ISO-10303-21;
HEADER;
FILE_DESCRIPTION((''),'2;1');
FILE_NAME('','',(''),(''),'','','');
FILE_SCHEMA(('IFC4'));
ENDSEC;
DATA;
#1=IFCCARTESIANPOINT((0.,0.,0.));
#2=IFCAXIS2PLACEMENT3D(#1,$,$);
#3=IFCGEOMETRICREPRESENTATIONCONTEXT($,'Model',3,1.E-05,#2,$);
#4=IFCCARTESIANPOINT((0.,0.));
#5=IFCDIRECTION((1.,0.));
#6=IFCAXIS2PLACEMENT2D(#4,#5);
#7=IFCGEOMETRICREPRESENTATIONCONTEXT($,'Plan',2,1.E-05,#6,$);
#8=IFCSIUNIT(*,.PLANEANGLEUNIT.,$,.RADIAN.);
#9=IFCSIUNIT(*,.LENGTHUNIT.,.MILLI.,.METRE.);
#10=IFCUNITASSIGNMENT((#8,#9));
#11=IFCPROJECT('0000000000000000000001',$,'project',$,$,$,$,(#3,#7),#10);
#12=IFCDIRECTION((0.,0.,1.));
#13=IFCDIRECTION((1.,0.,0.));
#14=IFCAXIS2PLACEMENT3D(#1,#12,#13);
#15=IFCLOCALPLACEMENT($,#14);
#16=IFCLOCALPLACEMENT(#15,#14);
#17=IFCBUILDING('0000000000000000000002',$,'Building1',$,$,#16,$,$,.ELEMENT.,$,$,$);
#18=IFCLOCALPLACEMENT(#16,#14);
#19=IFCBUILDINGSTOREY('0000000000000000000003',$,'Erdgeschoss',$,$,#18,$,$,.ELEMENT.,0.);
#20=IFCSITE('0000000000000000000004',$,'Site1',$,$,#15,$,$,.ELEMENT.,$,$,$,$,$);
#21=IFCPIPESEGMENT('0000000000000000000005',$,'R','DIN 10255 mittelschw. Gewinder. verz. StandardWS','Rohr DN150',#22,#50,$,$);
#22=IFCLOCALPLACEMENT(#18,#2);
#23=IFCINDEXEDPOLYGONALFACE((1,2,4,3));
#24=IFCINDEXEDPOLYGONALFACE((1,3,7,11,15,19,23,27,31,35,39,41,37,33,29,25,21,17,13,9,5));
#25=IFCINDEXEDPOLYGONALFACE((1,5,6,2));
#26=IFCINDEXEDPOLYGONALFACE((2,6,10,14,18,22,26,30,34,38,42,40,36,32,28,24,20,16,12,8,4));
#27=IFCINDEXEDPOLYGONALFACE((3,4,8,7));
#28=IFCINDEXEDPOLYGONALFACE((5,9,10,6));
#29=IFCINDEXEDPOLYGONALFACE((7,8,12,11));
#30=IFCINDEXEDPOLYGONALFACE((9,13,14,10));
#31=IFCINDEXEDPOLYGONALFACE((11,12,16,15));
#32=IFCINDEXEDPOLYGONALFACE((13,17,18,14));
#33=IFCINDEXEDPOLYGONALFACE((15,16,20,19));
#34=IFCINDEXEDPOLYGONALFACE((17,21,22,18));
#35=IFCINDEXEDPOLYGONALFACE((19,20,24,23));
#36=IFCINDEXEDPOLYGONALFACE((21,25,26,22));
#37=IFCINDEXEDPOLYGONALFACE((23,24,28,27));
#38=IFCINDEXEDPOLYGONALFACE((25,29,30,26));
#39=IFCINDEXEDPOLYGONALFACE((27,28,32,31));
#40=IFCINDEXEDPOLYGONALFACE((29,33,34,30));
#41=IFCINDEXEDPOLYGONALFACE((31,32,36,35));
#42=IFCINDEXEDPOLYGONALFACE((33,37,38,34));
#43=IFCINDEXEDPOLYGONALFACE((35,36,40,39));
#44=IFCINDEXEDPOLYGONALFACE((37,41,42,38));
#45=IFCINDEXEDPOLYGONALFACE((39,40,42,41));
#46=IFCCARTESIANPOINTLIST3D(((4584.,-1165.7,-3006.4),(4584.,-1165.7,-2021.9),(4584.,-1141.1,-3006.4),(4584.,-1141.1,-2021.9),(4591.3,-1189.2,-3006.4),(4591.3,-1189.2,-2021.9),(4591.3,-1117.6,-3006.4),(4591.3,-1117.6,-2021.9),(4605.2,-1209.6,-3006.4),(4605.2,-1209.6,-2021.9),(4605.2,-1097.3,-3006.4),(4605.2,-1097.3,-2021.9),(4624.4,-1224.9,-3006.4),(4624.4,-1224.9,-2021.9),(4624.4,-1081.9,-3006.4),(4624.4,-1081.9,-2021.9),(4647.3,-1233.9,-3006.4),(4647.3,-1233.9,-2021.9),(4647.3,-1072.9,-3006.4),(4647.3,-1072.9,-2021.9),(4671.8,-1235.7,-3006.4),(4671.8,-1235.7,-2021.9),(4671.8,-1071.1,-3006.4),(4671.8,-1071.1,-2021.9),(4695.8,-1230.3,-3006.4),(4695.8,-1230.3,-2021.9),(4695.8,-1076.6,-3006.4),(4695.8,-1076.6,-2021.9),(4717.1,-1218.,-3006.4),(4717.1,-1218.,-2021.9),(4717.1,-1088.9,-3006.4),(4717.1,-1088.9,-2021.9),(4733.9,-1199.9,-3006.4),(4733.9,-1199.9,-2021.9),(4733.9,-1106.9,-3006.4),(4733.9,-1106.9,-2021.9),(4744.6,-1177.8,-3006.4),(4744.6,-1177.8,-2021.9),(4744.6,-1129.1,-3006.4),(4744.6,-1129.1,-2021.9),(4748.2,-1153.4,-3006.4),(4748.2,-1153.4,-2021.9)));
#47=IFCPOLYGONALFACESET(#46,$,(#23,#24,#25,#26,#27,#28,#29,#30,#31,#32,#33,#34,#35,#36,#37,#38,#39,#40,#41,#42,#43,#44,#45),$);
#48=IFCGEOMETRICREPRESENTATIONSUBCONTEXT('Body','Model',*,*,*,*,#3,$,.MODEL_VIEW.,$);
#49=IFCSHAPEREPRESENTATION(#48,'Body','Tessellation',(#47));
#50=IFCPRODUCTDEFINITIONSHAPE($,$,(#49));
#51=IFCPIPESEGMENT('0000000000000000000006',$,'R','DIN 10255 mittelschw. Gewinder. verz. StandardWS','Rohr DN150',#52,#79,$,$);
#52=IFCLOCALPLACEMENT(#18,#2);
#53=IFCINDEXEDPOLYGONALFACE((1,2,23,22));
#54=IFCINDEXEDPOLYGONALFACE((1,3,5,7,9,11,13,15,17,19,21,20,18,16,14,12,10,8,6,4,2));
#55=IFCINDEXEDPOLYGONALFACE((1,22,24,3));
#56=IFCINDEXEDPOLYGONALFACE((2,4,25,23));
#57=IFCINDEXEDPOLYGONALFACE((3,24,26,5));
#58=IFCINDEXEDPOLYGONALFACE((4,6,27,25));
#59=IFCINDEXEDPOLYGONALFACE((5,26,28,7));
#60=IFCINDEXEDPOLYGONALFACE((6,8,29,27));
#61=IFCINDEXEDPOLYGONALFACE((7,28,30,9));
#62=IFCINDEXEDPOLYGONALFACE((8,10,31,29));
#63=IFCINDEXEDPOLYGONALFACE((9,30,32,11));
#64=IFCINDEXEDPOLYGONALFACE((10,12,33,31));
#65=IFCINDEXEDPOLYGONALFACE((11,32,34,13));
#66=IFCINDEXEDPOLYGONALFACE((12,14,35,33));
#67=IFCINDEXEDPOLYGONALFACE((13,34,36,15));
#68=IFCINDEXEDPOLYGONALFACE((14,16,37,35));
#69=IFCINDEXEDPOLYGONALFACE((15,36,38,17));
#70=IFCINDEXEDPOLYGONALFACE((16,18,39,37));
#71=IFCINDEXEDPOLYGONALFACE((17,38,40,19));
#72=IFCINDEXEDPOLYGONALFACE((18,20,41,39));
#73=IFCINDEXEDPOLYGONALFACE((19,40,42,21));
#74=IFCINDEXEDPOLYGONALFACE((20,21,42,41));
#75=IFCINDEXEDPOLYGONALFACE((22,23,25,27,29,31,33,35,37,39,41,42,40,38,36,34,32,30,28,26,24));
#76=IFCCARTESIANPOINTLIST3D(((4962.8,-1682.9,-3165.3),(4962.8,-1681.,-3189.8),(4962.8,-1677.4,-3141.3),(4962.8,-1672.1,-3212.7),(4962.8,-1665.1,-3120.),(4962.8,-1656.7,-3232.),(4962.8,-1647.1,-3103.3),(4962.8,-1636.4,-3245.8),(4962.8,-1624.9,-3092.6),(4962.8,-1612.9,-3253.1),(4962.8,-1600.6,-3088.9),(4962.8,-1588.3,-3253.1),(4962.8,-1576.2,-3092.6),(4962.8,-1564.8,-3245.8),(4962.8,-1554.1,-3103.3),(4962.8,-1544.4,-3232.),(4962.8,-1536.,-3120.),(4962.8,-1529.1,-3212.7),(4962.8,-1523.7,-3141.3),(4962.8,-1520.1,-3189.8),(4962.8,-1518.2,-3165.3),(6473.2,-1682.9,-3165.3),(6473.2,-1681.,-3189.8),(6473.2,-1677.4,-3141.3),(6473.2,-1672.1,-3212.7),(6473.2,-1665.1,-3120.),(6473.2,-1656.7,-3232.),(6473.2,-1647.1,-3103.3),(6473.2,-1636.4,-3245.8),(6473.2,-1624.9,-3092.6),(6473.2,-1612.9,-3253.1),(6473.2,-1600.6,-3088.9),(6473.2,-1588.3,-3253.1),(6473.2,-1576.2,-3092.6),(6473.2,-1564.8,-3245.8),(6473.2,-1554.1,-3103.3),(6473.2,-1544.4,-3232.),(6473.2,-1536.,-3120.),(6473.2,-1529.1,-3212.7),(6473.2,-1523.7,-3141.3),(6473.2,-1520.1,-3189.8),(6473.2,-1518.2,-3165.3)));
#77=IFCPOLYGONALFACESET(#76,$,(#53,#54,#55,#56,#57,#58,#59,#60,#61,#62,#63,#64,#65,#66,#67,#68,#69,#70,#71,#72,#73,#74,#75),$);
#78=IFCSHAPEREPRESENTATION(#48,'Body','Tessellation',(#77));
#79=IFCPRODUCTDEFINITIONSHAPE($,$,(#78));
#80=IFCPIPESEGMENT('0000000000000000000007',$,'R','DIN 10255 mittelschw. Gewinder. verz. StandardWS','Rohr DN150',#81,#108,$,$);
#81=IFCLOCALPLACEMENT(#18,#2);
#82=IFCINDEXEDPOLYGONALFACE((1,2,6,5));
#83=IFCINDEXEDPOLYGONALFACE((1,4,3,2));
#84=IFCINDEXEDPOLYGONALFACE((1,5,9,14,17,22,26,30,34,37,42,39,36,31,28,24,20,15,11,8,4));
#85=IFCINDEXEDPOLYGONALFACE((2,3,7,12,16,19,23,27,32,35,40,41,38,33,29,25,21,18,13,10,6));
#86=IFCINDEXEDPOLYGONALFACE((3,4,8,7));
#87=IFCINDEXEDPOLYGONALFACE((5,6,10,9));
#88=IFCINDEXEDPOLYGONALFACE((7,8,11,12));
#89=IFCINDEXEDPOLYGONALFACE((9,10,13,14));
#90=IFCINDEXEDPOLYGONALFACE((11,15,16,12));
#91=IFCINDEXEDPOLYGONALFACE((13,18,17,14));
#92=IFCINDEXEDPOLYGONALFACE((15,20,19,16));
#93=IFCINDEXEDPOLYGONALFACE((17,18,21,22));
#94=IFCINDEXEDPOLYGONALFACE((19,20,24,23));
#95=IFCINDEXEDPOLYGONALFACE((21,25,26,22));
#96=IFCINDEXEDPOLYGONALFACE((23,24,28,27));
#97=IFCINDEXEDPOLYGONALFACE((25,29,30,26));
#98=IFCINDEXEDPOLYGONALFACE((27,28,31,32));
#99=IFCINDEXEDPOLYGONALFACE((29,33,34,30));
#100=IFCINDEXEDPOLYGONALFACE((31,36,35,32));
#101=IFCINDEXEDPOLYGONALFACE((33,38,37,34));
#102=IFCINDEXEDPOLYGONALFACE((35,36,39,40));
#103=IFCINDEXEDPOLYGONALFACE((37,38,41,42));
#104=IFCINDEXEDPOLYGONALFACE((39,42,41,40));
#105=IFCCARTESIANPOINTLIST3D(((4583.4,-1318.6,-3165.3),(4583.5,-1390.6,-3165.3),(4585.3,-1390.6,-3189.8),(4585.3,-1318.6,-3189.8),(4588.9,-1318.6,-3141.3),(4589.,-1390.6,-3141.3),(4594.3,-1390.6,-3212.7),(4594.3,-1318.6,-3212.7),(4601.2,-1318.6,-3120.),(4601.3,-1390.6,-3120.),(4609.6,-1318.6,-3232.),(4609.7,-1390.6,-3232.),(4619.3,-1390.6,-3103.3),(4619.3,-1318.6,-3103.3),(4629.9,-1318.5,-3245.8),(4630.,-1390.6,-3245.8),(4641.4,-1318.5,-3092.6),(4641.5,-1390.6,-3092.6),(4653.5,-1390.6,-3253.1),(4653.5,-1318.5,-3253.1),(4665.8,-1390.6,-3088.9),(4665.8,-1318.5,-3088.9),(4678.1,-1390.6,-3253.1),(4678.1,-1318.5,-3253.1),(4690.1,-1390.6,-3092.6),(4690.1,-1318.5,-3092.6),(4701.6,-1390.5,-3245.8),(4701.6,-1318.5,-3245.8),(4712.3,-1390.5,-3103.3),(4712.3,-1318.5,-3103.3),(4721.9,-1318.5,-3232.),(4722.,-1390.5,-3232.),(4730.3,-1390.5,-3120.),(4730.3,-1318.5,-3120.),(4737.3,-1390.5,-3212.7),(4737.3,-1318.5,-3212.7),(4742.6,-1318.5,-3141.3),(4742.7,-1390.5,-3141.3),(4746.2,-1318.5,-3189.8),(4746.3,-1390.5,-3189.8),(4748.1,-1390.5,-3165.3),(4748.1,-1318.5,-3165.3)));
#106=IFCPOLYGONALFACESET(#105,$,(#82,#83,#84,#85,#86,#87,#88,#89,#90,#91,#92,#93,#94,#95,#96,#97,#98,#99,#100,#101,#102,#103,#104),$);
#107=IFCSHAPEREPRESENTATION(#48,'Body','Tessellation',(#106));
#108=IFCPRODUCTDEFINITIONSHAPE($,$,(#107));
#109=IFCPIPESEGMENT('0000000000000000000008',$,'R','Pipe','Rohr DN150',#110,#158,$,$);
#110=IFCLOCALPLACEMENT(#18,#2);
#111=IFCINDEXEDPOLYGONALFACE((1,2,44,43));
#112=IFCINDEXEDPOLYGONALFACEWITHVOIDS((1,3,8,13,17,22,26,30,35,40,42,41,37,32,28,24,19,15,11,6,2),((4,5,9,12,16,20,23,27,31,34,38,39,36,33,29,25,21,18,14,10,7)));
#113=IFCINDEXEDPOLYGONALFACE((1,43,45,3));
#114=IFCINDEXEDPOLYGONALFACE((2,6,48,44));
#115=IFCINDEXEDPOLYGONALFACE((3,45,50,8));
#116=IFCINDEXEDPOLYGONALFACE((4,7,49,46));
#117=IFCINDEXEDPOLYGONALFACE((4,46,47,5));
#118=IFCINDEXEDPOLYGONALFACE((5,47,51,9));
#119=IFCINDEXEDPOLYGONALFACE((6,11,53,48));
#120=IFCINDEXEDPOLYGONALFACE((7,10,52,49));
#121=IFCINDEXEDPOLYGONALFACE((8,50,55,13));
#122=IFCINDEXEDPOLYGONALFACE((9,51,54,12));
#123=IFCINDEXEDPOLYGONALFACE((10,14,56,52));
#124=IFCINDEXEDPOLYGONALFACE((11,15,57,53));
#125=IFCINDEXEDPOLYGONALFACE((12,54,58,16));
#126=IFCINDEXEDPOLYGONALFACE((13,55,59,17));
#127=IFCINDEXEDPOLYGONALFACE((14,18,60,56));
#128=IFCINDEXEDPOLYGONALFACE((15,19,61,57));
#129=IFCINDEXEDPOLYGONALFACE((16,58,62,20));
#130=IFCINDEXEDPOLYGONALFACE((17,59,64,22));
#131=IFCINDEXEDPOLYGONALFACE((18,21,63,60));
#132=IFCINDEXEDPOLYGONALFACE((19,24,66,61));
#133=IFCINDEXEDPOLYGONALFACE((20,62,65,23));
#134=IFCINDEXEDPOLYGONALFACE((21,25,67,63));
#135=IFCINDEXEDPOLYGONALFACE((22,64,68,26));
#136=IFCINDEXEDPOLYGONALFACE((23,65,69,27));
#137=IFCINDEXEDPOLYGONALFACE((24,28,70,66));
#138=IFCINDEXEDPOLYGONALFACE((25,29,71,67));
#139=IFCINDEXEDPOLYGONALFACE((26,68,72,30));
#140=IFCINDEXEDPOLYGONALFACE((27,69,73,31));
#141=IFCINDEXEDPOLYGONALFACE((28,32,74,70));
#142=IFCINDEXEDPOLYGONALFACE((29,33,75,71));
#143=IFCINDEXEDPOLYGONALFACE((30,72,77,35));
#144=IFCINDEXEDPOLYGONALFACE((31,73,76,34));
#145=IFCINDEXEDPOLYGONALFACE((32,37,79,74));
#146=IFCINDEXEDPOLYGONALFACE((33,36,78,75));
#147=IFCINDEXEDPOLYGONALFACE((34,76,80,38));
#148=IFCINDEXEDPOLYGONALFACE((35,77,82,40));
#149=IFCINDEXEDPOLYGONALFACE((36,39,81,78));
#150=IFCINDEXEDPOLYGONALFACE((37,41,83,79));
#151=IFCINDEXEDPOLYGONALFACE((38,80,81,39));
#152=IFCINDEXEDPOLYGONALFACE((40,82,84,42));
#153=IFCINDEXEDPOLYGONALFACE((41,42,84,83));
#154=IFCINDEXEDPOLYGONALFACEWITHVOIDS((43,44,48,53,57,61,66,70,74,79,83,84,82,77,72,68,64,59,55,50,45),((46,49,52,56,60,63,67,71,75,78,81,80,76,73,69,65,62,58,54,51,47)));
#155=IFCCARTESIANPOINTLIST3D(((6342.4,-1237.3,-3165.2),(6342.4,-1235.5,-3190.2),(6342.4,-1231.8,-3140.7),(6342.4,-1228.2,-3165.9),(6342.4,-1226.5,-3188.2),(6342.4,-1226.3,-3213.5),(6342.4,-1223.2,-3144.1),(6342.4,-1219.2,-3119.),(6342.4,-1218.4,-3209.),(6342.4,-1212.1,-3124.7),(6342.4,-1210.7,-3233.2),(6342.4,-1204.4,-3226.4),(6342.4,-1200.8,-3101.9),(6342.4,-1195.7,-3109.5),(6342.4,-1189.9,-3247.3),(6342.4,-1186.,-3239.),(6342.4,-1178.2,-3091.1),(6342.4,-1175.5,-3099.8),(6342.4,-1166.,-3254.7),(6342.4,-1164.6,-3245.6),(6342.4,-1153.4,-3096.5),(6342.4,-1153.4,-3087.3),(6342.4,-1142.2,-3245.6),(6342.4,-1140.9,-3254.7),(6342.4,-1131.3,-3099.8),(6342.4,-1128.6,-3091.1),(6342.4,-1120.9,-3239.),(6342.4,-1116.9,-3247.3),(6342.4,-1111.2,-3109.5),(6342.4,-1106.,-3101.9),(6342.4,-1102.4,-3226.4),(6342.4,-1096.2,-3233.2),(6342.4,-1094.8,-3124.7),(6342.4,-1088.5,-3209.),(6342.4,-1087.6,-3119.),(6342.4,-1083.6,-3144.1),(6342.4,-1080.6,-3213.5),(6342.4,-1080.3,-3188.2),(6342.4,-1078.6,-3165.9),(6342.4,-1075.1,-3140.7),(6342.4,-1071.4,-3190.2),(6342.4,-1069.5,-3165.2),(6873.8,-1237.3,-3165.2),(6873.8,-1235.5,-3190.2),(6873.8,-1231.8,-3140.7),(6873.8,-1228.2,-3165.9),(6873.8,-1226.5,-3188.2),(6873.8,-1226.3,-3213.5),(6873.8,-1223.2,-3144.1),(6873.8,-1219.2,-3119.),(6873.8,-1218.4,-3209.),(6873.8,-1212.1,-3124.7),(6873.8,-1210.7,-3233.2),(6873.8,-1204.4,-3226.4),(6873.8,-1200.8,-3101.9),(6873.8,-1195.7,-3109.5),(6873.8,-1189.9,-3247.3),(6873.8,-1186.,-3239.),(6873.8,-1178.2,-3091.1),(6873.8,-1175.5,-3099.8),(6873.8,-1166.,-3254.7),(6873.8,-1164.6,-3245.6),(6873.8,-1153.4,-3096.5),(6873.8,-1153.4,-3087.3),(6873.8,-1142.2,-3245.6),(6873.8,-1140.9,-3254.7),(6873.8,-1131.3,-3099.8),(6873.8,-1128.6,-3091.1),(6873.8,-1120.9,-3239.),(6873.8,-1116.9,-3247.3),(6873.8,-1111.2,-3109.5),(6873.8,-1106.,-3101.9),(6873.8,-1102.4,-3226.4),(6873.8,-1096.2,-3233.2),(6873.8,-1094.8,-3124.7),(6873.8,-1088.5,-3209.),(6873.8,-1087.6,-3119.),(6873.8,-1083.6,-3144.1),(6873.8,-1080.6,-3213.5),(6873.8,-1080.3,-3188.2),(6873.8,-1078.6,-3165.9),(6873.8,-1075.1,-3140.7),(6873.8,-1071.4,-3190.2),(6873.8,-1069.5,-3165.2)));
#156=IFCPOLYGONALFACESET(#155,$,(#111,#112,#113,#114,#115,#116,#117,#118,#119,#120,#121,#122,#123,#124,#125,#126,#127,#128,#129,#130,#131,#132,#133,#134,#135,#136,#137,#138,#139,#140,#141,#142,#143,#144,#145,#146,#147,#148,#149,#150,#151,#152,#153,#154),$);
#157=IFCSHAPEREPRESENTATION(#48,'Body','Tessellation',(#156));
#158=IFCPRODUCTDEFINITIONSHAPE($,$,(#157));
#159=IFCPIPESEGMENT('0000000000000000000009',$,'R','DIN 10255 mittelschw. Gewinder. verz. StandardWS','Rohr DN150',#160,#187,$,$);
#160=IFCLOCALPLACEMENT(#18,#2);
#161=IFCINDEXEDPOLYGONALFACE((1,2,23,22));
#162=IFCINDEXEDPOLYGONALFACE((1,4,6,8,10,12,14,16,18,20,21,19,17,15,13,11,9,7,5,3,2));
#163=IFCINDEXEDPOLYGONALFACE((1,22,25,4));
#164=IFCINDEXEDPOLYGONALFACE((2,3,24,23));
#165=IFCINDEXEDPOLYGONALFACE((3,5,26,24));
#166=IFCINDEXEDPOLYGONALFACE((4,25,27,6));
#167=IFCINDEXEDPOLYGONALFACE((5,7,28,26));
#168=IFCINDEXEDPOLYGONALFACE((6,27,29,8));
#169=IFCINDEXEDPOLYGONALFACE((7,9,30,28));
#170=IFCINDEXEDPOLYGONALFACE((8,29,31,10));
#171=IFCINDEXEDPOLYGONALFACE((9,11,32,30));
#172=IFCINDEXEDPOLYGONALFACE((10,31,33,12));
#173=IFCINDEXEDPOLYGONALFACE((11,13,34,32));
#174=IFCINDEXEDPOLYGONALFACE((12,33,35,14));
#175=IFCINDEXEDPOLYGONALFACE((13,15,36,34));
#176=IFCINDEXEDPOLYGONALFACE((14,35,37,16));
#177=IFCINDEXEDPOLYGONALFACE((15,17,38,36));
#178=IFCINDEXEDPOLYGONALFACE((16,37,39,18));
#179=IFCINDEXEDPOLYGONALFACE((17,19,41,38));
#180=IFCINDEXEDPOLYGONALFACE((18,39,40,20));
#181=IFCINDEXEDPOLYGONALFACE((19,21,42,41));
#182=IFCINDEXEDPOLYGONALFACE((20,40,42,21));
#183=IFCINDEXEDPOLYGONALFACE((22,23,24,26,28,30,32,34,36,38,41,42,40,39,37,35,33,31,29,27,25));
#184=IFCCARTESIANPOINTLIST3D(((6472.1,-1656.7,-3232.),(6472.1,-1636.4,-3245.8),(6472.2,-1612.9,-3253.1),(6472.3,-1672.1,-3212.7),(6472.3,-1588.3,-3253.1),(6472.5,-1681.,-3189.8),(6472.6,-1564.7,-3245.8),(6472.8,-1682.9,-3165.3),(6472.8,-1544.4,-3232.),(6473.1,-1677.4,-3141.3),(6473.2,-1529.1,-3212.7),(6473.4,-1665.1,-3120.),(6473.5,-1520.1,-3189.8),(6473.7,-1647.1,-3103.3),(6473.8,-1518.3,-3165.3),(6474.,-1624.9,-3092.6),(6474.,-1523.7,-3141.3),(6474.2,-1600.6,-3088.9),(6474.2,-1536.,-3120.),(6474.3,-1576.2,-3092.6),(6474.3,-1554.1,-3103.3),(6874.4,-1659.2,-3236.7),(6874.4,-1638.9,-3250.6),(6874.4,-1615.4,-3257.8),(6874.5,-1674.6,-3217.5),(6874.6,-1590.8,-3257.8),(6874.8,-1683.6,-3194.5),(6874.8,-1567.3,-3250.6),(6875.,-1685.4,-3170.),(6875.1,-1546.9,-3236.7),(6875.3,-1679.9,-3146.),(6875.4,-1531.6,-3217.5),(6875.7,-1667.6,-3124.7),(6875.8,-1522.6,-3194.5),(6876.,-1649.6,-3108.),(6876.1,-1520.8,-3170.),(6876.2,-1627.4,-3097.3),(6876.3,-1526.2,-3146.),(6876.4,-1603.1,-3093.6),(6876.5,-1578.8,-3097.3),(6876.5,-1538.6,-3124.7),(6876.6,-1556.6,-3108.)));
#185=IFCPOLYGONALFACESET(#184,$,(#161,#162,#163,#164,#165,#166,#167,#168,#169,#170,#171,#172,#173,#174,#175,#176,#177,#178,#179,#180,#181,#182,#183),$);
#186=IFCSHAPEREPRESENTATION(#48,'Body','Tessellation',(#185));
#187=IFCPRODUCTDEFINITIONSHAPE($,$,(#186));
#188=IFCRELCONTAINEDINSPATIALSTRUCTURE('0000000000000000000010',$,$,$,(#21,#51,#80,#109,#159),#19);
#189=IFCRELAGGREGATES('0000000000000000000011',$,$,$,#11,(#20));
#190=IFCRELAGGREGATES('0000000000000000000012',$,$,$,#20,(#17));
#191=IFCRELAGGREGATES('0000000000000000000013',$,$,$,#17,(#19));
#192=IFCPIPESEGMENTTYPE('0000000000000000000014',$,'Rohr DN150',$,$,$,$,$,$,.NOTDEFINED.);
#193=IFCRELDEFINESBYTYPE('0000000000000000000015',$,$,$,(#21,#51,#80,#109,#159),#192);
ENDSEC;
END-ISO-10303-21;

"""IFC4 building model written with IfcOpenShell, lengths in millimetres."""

from ifc_helpers import new_model, si_unit, frame, origin, origin_with_axes, origin_2d_with_axis, place, context, subcontext, project, spatial, circle, hollow_circle, extrude, type_object, element, save


model = new_model("IFC4")

# Units and contexts
model_context = context("Model", 3, precision=1e-05, world=origin())
plan_context = context("Plan", 2, precision=1e-05, world=origin_2d_with_axis())
body_context = subcontext(model_context, "Body", "Model", "MODEL_VIEW")
ifc_project = project(units=[si_unit("PLANEANGLEUNIT", "RADIAN"), si_unit("LENGTHUNIT", "METRE", prefix="MILLI")], contexts=[model_context, plan_context])

# Site, building, storey
site_placement = place(None, origin_with_axes())
site = spatial("IfcSite", under=ifc_project, at=site_placement, Name="Site1", CompositionType="ELEMENT")
building_placement = place(site_placement, origin_with_axes())
building = spatial("IfcBuilding", under=site, at=building_placement, Name="Building1", CompositionType="ELEMENT")
storey_placement = place(building_placement, origin_with_axes())
storey = spatial("IfcBuildingStorey", under=building, at=storey_placement, Name="Erdgeschoss", CompositionType="ELEMENT", Elevation=0.0)

# Pipe segments
pipe_segment_type_1 = type_object("IfcPipeSegmentType", Name="Rohr DN150", PredefinedType="NOTDEFINED")
pipe_segment_1_placement = place(storey_placement, frame((4665.7, -1153.6, -2514.1), z_axis=(0.0, 0.0, 1.0), x_axis=(1.0, 0.0, 0.0)))
element("IfcPipeSegment", 1, at=pipe_segment_1_placement, inside=storey, type_object=pipe_segment_type_1, Name="R", Description="DIN 10255 mittelschw. Gewinder. verz. StandardWS", ObjectType="Rohr DN150", context=body_context, shape_type="SolidModel", body=[
    extrude(circle(Radius=82.5, at=origin_2d_with_axis()), frame((0.0, 0.2, -492.3), z_axis=(0.0, 0.0, 1.0), x_axis=(1.0, 0.0, 0.0)), (0.0, 0.0, 1.0), 984.5),
])
pipe_segment_2_placement = place(storey_placement, frame((5718.0, -1600.7, -3171.5), z_axis=(0.0, 0.0, 1.0), x_axis=(1.0, 0.0, 0.0)))
element("IfcPipeSegment", 2, at=pipe_segment_2_placement, inside=storey, type_object=pipe_segment_type_1, Name="R", Description="DIN 10255 mittelschw. Gewinder. verz. StandardWS", ObjectType="Rohr DN150", context=body_context, shape_type="SolidModel", body=[
    extrude(circle(Radius=82.5, at=origin_2d_with_axis()), frame((755.2, 0.1, 0.0), z_axis=(-1.0, 0.0, 0.0), x_axis=(0.0, 0.0, 1.0)), (0.0, 0.0, 1.0), 1510.4),
])
pipe_segment_3_placement = place(storey_placement, frame((4665.6, -1354.5, -3171.5), z_axis=(0.0, 0.0, 1.0), x_axis=(1.0, 0.0, 0.0)))
element("IfcPipeSegment", 3, at=pipe_segment_3_placement, inside=storey, type_object=pipe_segment_type_1, Name="R", Description="DIN 10255 mittelschw. Gewinder. verz. StandardWS", ObjectType="Rohr DN150", context=body_context, shape_type="SolidModel", body=[
    extrude(circle(Radius=82.5, at=origin_2d_with_axis()), frame((0.2, -36.0, 0.0), z_axis=(-0.000562, 1.0, 0.0), x_axis=(0.0, 0.0, 1.0)), (0.0, 0.0, 1.0), 72.0),
])
pipe_segment_4_placement = place(storey_placement, frame((6608.1, -1153.6, -3171.5), z_axis=(0.0, 0.0, 1.0), x_axis=(1.0, 0.0, 0.0)))
element("IfcPipeSegment", 4, at=pipe_segment_4_placement, inside=storey, type_object=pipe_segment_type_1, Name="R", Description="Pipe", ObjectType="Rohr DN150", context=body_context, shape_type="SolidModel", body=[
    extrude(hollow_circle(Radius=84.2, WallThickness=9.2, at=origin_2d_with_axis()), frame((265.7, 0.1, 0.0), z_axis=(-1.0, 0.0, 0.0), x_axis=(0.0, 0.0, 1.0)), (0.0, 0.0, 1.0), 531.3),
])
pipe_segment_5_placement = place(storey_placement, frame((6674.3, -1602.0, -3173.8), z_axis=(0.0, 0.0, 1.0), x_axis=(1.0, 0.0, 0.0)))
element("IfcPipeSegment", 5, at=pipe_segment_5_placement, inside=storey, type_object=pipe_segment_type_1, Name="R", Description="DIN 10255 mittelschw. Gewinder. verz. StandardWS", ObjectType="Rohr DN150", context=body_context, shape_type="SolidModel", body=[
    extrude(circle(Radius=82.5, at=origin_2d_with_axis()), frame((201.1, -1.1, -2.4), z_axis=(-0.999912, 0.00627, 0.011706), x_axis=(0.0, 0.0, 1.0)), (0.0, 0.0, 1.0), 402.3),
])

save(model, "model.ifc")
